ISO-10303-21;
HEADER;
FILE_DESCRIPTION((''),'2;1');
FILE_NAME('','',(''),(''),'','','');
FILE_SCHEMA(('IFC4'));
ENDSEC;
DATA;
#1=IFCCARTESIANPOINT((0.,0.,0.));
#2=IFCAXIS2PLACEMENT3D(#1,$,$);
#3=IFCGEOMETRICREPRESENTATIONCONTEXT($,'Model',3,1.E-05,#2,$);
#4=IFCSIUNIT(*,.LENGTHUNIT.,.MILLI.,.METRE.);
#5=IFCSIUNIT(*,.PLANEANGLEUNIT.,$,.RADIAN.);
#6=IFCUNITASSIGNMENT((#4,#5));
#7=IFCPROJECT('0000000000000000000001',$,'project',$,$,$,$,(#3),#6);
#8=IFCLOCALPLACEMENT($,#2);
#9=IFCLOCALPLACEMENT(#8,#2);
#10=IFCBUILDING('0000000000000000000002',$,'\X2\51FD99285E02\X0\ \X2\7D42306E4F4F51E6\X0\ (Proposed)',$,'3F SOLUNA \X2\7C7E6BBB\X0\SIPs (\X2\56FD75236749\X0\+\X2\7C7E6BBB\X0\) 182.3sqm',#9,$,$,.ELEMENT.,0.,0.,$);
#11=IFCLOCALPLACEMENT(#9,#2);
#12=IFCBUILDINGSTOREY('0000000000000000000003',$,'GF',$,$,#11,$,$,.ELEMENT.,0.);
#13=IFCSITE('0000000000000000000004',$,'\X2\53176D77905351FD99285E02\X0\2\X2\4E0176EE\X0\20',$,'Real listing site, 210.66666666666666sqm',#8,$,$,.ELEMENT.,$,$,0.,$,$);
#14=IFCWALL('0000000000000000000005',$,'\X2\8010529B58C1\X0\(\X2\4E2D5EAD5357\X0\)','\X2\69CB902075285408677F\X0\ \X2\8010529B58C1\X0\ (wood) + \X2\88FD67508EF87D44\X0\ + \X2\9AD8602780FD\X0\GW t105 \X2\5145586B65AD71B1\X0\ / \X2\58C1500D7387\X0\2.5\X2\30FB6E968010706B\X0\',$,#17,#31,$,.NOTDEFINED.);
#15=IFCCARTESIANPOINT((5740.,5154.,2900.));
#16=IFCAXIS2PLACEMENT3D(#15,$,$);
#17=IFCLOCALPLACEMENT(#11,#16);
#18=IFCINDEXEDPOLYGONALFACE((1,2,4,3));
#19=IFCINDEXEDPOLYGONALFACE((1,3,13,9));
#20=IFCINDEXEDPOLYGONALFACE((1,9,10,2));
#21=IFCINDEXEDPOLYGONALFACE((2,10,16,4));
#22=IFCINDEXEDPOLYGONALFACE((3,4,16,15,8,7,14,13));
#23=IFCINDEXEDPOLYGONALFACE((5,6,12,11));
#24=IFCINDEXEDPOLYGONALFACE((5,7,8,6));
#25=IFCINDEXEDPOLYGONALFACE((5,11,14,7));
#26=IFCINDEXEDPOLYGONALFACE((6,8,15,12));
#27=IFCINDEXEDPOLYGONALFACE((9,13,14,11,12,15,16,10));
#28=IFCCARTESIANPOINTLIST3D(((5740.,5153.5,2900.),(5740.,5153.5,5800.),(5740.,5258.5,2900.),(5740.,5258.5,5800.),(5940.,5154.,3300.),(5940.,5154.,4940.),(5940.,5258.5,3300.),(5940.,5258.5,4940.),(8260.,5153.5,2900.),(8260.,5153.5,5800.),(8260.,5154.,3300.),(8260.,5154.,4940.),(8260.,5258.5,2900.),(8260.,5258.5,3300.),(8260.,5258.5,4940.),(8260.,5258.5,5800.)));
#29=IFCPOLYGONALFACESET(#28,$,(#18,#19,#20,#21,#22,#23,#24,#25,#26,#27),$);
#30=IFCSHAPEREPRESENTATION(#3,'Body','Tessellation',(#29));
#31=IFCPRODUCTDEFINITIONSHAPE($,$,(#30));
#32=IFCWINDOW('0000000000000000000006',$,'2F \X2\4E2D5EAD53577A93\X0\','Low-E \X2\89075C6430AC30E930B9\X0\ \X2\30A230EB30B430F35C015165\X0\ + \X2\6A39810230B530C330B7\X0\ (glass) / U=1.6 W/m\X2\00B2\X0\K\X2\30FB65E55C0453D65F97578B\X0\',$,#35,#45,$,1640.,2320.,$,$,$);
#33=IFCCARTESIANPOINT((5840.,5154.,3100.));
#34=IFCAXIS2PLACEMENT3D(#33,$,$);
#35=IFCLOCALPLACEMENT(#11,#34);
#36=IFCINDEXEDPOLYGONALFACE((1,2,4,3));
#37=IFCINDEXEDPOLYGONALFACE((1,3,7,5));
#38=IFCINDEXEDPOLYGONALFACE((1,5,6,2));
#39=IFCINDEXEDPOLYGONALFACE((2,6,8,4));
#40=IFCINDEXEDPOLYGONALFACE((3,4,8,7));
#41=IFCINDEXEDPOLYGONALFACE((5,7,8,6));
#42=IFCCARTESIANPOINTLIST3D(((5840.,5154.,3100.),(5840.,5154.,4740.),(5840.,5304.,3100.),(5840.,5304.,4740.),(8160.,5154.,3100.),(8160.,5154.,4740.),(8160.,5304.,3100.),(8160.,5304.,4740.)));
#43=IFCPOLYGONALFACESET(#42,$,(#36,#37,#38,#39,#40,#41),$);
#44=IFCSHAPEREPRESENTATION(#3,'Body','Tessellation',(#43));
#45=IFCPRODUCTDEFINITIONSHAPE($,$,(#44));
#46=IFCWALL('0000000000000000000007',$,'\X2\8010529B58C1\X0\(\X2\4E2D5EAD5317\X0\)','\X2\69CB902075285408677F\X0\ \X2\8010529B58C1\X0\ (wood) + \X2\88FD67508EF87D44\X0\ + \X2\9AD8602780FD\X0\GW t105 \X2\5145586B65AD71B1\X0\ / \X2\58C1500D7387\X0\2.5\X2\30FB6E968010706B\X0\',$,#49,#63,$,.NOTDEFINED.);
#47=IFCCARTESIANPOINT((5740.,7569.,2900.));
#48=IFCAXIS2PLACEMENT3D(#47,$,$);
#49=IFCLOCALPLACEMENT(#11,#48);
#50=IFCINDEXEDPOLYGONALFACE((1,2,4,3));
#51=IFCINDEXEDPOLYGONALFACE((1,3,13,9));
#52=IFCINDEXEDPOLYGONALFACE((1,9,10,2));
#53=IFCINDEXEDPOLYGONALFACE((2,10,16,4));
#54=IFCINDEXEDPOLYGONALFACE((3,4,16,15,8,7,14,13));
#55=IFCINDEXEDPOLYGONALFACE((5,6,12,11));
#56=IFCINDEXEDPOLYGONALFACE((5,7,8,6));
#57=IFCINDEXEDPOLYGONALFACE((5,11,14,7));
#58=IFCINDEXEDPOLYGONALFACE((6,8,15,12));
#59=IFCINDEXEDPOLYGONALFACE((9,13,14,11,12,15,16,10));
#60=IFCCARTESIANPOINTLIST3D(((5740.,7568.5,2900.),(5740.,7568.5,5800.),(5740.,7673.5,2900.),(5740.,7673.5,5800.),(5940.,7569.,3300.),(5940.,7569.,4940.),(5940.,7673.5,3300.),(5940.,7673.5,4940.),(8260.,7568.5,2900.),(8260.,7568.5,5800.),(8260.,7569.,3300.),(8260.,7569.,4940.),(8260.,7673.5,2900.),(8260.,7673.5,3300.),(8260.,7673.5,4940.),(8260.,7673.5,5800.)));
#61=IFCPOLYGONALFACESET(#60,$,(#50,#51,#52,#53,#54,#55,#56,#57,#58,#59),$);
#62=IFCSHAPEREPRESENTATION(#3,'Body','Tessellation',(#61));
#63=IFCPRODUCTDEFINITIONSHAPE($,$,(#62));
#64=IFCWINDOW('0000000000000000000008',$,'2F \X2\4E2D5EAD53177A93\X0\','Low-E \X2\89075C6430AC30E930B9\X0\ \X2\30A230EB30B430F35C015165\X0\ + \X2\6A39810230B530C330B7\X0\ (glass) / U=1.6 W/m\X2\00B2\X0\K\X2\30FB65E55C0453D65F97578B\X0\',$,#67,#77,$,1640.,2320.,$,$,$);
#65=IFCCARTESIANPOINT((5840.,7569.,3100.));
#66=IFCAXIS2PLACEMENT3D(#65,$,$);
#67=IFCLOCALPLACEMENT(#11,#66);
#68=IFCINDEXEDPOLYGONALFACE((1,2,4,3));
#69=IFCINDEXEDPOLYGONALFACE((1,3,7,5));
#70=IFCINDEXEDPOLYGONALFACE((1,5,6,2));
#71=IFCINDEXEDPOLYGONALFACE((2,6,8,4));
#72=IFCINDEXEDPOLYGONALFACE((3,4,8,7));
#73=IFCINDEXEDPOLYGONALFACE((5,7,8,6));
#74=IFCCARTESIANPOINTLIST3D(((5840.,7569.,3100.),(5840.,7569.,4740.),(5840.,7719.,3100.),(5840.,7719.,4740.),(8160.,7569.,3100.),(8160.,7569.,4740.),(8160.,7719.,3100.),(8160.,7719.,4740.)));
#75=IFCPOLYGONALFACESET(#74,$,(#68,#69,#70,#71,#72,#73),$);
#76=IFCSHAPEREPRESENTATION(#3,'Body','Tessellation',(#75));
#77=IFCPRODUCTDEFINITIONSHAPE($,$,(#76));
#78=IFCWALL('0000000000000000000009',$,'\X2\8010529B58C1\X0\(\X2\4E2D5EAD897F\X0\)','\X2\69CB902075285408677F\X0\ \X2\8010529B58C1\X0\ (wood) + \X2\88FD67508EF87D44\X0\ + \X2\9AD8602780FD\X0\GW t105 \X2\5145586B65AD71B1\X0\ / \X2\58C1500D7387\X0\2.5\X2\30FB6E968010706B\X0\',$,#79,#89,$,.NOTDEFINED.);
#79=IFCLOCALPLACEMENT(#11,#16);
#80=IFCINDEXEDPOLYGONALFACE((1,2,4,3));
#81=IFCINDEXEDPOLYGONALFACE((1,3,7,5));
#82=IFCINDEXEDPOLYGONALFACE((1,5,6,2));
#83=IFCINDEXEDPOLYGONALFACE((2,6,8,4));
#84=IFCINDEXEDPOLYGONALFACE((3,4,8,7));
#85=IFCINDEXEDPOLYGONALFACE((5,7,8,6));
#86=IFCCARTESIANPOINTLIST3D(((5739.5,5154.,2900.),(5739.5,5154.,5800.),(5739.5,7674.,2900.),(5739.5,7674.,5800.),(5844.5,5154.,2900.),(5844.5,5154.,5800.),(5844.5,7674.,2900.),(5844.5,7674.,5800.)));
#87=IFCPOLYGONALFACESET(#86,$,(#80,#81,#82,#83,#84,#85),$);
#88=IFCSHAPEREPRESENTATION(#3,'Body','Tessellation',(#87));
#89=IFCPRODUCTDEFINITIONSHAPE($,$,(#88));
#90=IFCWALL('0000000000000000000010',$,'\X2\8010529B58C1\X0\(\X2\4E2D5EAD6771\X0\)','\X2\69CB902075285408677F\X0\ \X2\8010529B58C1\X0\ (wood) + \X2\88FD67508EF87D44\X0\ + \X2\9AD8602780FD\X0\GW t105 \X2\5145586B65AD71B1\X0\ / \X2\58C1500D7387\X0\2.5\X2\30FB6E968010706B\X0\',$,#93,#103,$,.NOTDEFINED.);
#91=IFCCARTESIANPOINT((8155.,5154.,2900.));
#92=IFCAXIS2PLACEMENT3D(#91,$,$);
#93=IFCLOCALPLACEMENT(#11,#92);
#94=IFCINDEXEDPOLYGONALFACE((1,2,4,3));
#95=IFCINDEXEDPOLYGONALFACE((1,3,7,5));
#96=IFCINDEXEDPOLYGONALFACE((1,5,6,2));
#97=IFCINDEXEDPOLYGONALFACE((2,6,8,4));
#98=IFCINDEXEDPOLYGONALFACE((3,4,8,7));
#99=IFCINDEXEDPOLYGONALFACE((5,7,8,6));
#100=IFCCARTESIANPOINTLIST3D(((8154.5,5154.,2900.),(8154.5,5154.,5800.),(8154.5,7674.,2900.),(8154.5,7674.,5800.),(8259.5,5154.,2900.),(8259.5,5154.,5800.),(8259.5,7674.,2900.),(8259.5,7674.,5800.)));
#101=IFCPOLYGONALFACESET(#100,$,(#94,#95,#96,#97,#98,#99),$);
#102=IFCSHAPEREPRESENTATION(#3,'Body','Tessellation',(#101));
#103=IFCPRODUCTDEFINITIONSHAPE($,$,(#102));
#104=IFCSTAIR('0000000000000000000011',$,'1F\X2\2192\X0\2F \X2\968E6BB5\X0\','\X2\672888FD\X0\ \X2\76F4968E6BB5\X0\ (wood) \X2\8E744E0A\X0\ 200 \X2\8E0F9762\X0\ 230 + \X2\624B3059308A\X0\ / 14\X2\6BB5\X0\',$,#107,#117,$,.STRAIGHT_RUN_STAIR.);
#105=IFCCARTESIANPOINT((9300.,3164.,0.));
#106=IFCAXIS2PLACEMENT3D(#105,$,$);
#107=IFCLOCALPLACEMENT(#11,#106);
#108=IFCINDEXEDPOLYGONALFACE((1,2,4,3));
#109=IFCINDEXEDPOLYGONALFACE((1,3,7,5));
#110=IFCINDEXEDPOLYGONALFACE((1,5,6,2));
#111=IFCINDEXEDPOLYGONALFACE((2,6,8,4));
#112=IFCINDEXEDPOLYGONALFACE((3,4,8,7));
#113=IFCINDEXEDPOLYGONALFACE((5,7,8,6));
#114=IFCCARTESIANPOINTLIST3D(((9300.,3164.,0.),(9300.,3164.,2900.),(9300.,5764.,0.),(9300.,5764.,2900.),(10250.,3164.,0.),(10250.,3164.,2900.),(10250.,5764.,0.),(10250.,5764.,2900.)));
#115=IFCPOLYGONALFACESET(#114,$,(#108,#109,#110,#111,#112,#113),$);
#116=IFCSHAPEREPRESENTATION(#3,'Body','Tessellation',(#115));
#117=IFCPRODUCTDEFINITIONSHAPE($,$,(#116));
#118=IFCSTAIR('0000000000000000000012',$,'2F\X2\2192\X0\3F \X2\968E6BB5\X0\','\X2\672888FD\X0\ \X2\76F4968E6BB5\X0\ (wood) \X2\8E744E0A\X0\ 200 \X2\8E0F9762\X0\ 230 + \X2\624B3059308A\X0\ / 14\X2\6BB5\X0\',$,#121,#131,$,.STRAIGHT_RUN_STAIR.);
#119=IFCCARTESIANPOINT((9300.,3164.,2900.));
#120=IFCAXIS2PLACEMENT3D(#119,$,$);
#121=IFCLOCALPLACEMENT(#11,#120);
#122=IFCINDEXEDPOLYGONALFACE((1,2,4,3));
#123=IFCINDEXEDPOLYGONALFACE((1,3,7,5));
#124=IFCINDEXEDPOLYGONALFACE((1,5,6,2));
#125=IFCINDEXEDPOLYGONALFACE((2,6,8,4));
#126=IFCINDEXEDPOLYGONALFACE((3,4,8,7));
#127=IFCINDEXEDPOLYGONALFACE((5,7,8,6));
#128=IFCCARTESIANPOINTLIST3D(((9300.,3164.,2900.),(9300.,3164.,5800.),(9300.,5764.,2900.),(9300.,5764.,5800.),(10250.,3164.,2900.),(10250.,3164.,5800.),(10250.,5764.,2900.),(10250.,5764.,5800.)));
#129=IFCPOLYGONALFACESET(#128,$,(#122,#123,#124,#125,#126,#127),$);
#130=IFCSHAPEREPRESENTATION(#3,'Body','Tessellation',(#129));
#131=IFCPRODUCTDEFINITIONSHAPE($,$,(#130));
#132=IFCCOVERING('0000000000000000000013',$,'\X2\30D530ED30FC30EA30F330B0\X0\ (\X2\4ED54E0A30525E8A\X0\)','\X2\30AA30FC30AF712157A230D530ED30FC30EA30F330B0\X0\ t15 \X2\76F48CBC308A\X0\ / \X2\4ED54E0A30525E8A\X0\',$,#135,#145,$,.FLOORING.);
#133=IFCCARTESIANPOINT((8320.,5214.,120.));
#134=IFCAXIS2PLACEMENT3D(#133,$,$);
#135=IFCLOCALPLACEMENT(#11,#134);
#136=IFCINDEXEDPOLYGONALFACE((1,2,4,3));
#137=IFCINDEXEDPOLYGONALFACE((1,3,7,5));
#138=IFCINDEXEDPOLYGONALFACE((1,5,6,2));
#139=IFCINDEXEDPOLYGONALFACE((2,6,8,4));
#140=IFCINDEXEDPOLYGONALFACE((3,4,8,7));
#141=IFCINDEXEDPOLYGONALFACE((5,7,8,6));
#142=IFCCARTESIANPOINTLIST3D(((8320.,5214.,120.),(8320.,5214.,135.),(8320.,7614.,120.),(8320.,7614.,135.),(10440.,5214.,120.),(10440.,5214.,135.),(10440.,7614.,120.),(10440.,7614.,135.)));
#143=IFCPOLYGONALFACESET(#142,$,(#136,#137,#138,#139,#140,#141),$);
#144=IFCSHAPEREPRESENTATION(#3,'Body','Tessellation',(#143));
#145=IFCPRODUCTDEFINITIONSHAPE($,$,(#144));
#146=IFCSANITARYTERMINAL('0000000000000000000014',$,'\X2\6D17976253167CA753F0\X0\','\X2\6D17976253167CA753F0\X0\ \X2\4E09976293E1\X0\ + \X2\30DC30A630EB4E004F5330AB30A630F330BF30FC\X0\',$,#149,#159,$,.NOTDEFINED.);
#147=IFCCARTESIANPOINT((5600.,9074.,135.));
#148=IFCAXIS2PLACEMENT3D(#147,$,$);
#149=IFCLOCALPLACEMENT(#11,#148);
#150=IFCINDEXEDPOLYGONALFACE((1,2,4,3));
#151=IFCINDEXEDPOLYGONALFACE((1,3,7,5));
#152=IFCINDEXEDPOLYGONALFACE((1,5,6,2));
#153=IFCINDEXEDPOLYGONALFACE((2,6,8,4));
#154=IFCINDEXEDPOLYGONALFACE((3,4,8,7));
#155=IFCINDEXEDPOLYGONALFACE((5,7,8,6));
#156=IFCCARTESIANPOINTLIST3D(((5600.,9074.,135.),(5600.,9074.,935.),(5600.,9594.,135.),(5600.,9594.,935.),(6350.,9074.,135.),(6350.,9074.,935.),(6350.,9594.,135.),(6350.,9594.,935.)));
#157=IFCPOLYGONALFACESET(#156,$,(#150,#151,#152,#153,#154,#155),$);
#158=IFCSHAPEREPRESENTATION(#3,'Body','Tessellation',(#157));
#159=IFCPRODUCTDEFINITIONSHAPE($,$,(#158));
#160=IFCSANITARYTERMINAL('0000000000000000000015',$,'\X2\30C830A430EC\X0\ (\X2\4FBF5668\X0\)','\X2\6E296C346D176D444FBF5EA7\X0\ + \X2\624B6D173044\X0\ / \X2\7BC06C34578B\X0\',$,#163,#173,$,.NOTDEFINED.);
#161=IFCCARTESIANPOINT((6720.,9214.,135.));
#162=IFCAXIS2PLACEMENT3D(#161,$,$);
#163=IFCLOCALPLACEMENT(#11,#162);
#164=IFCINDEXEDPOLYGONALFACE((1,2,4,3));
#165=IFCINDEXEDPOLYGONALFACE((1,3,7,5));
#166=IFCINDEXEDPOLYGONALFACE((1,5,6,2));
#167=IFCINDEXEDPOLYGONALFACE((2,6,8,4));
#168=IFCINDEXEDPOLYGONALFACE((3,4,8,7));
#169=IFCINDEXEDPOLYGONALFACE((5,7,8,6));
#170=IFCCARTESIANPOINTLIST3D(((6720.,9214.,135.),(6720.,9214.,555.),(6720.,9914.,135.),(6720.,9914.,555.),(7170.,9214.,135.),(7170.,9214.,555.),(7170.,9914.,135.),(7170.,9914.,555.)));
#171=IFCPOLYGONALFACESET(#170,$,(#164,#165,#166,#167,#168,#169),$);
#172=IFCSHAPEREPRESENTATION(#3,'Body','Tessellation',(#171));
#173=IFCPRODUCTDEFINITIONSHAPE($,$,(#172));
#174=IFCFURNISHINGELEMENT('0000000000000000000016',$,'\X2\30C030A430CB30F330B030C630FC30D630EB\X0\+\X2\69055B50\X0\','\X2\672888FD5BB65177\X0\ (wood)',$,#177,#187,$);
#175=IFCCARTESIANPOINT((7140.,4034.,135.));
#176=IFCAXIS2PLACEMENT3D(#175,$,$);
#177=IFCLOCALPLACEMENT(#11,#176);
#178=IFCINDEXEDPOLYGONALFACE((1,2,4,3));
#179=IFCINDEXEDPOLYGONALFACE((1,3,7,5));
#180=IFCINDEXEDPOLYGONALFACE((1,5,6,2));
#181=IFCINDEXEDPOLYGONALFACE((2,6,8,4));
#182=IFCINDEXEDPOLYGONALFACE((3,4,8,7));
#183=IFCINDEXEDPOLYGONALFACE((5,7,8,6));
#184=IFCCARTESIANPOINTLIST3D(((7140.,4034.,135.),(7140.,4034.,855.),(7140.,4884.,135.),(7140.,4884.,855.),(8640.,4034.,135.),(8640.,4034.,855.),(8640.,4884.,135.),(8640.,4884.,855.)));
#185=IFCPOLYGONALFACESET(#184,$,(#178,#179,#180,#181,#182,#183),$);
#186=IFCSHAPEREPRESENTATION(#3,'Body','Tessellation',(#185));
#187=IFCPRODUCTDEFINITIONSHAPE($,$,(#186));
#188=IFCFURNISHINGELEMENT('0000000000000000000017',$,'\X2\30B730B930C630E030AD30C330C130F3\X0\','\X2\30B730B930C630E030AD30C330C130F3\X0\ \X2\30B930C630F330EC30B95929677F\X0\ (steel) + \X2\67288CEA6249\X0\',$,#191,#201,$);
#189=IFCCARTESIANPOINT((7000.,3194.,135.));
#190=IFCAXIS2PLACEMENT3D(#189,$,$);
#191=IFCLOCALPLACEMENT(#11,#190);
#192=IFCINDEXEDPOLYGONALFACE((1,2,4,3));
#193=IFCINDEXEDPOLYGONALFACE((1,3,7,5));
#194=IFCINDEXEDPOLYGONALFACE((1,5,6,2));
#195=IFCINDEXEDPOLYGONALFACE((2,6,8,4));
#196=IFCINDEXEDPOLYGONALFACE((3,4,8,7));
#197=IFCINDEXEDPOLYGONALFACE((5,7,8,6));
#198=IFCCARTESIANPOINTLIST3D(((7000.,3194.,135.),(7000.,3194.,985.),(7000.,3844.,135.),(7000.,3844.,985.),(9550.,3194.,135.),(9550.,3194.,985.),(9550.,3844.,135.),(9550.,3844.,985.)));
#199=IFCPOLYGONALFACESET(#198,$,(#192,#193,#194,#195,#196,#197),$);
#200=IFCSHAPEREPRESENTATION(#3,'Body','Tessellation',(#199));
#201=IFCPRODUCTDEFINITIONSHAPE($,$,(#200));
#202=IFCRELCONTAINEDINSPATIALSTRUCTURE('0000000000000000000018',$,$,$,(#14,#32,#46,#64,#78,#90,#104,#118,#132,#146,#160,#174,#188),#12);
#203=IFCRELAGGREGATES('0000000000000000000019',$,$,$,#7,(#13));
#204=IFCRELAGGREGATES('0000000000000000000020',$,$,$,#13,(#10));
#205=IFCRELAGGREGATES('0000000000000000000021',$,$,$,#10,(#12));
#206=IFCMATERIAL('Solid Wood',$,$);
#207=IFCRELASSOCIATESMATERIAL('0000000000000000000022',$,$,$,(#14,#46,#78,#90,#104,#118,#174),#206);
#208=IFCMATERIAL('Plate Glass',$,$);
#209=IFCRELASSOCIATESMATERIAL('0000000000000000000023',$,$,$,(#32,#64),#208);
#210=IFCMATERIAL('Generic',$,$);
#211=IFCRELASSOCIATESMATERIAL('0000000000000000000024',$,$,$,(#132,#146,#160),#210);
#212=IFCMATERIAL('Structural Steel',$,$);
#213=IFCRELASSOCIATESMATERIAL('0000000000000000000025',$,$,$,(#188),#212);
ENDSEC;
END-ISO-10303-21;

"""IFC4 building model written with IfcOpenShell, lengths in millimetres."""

from ifc_helpers import new_model, si_unit, frame, frame_2d, origin, place, context, project, spatial, rectangle, extrude, material, element, fill, save


model = new_model("IFC4")

# Units and contexts
model_context = context("Model", 3, precision=1e-05, world=origin())
ifc_project = project(units=[si_unit("LENGTHUNIT", "METRE", prefix="MILLI"), si_unit("PLANEANGLEUNIT", "RADIAN")], contexts=[model_context])

# Site, building, storey
site_placement = place(None, origin())
site = spatial("IfcSite", under=ifc_project, at=site_placement, Name="北海道函館市2丁目20", ObjectType="Real listing site, 210.66666666666666sqm", CompositionType="ELEMENT", RefElevation=0.0)
building_placement = place(site_placement, origin())
building = spatial("IfcBuilding", under=site, at=building_placement, Name="函館市 終の住処 (Proposed)", ObjectType="3F SOLUNA 籾殻SIPs (国産杉+籾殻) 182.3sqm", CompositionType="ELEMENT", ElevationOfRefHeight=0.0, ElevationOfTerrain=0.0)
storey_placement = place(building_placement, origin())
storey = spatial("IfcBuildingStorey", under=building, at=storey_placement, Name="GF", CompositionType="ELEMENT", Elevation=0.0)

# Shared definitions
ifc_material_1 = material(Name="Solid Wood")

# Shared definitions
ifc_material_2 = material(Name="Plate Glass")

# Walls, openings, windows
wall_1_placement = place(storey_placement, frame((5740.0, 5154.0, 2900.0)))
wall_1 = element("IfcWall", 1, at=wall_1_placement, inside=storey, material=ifc_material_1, Name="耐力壁(中庭南)", Description="構造用合板 耐力壁 (wood) + 製材軸組 + 高性能GW t105 充填断熱 / 壁倍率2.5・準耐火", PredefinedType="NOTDEFINED", context=model_context, shape_type="SweptSolid", body=[
    extrude(rectangle(XDim=2520.0, YDim=105.0, at=frame_2d((1260.0, 52.0))), frame((5740.0, 5154.0, 2900.0)), (0.0, 0.0, 1.0), 2900.0),
])
opening_1_placement = place(storey_placement, frame((5840.0, 5154.0, 3100.0)))
opening_1 = element("IfcOpeningElement", 2, at=opening_1_placement, cuts=wall_1, PredefinedType="NOTDEFINED", context=model_context, shape_type="SweptSolid", body=[
    extrude(rectangle(XDim=2320.0, YDim=150.0, at=frame_2d((1160.0, 75.0))), frame((5840.0, 5154.0, 3100.0)), (0.0, 0.0, 1.0), 1640.0),
])
window_1_placement = place(storey_placement, frame((5840.0, 5154.0, 3100.0)))
window_1 = element("IfcWindow", 3, at=window_1_placement, inside=storey, material=ifc_material_2, Name="2F 中庭南窓", Description="Low-E 複層ガラス アルゴン封入 + 樹脂サッシ (glass) / U=1.6 W/m²K・日射取得型", OverallHeight=1640.0, OverallWidth=2320.0, context=model_context, shape_type="SweptSolid", body=[
    extrude(rectangle(XDim=2320.0, YDim=150.0, at=frame_2d((1160.0, 75.0))), frame((5840.0, 5154.0, 3100.0)), (0.0, 0.0, 1.0), 1640.0),
])
fill(opening_1, window_1)
wall_2_placement = place(storey_placement, frame((5740.0, 7569.0, 2900.0)))
wall_2 = element("IfcWall", 4, at=wall_2_placement, inside=storey, material=ifc_material_1, Name="耐力壁(中庭北)", Description="構造用合板 耐力壁 (wood) + 製材軸組 + 高性能GW t105 充填断熱 / 壁倍率2.5・準耐火", PredefinedType="NOTDEFINED", context=model_context, shape_type="SweptSolid", body=[
    extrude(rectangle(XDim=2520.0, YDim=105.0, at=frame_2d((1260.0, 52.0))), frame((5740.0, 7569.0, 2900.0)), (0.0, 0.0, 1.0), 2900.0),
])
opening_2_placement = place(storey_placement, frame((5840.0, 7569.0, 3100.0)))
opening_2 = element("IfcOpeningElement", 5, at=opening_2_placement, cuts=wall_2, PredefinedType="NOTDEFINED", context=model_context, shape_type="SweptSolid", body=[
    extrude(rectangle(XDim=2320.0, YDim=150.0, at=frame_2d((1160.0, 75.0))), frame((5840.0, 7569.0, 3100.0)), (0.0, 0.0, 1.0), 1640.0),
])
window_2_placement = place(storey_placement, frame((5840.0, 7569.0, 3100.0)))
window_2 = element("IfcWindow", 6, at=window_2_placement, inside=storey, material=ifc_material_2, Name="2F 中庭北窓", Description="Low-E 複層ガラス アルゴン封入 + 樹脂サッシ (glass) / U=1.6 W/m²K・日射取得型", OverallHeight=1640.0, OverallWidth=2320.0, context=model_context, shape_type="SweptSolid", body=[
    extrude(rectangle(XDim=2320.0, YDim=150.0, at=frame_2d((1160.0, 75.0))), frame((5840.0, 7569.0, 3100.0)), (0.0, 0.0, 1.0), 1640.0),
])
fill(opening_2, window_2)

# Walls
wall_3_placement = place(storey_placement, frame((5740.0, 5154.0, 2900.0)))
element("IfcWall", 7, at=wall_3_placement, inside=storey, material=ifc_material_1, Name="耐力壁(中庭西)", Description="構造用合板 耐力壁 (wood) + 製材軸組 + 高性能GW t105 充填断熱 / 壁倍率2.5・準耐火", PredefinedType="NOTDEFINED", context=model_context, shape_type="SweptSolid", body=[
    extrude(rectangle(XDim=105.0, YDim=2520.0, at=frame_2d((52.0, 1260.0))), frame((5740.0, 5154.0, 2900.0)), (0.0, 0.0, 1.0), 2900.0),
])
wall_4_placement = place(storey_placement, frame((8155.0, 5154.0, 2900.0)))
element("IfcWall", 8, at=wall_4_placement, inside=storey, material=ifc_material_1, Name="耐力壁(中庭東)", Description="構造用合板 耐力壁 (wood) + 製材軸組 + 高性能GW t105 充填断熱 / 壁倍率2.5・準耐火", PredefinedType="NOTDEFINED", context=model_context, shape_type="SweptSolid", body=[
    extrude(rectangle(XDim=105.0, YDim=2520.0, at=frame_2d((52.0, 1260.0))), frame((8155.0, 5154.0, 2900.0)), (0.0, 0.0, 1.0), 2900.0),
])

# Stairs
stair_1_placement = place(storey_placement, frame((9300.0, 3164.0, 0.0)))
element("IfcStair", 9, at=stair_1_placement, inside=storey, material=ifc_material_1, Name="1F→2F 階段", Description="木製 直階段 (wood) 蹴上 200 踏面 230 + 手すり / 14段", PredefinedType="STRAIGHT_RUN_STAIR", context=model_context, shape_type="SweptSolid", body=[
    extrude(rectangle(XDim=950.0, YDim=2600.0, at=frame_2d((475.0, 1300.0))), frame((9300.0, 3164.0, 0.0)), (0.0, 0.0, 1.0), 2900.0),
])
stair_2_placement = place(storey_placement, frame((9300.0, 3164.0, 2900.0)))
element("IfcStair", 10, at=stair_2_placement, inside=storey, material=ifc_material_1, Name="2F→3F 階段", Description="木製 直階段 (wood) 蹴上 200 踏面 230 + 手すり / 14段", PredefinedType="STRAIGHT_RUN_STAIR", context=model_context, shape_type="SweptSolid", body=[
    extrude(rectangle(XDim=950.0, YDim=2600.0, at=frame_2d((475.0, 1300.0))), frame((9300.0, 3164.0, 2900.0)), (0.0, 0.0, 1.0), 2900.0),
])

# Covering
ifc_material_3 = material(Name="Generic")
covering_placement = place(storey_placement, frame((8320.0, 5214.0, 120.0)))
element("IfcCovering", 11, at=covering_placement, inside=storey, material=ifc_material_3, Name="フローリング (仕上げ床)", Description="オーク無垢フローリング t15 直貼り / 仕上げ床", PredefinedType="FLOORING", context=model_context, shape_type="SweptSolid", body=[
    extrude(rectangle(XDim=2120.0, YDim=2400.0, at=frame_2d((1060.0, 1200.0))), frame((8320.0, 5214.0, 120.0)), (0.0, 0.0, 1.0), 15.0),
])

# Sanitary terminals
sanitary_terminal_1_placement = place(storey_placement, frame((5600.0, 9074.0, 135.0)))
element("IfcSanitaryTerminal", 12, at=sanitary_terminal_1_placement, inside=storey, material=ifc_material_3, Name="洗面化粧台", Description="洗面化粧台 三面鏡 + ボウル一体カウンター", PredefinedType="NOTDEFINED", context=model_context, shape_type="SweptSolid", body=[
    extrude(rectangle(XDim=750.0, YDim=520.0, at=frame_2d((375.0, 260.0))), frame((5600.0, 9074.0, 135.0)), (0.0, 0.0, 1.0), 800.0),
])
sanitary_terminal_2_placement = place(storey_placement, frame((6720.0, 9214.0, 135.0)))
element("IfcSanitaryTerminal", 13, at=sanitary_terminal_2_placement, inside=storey, material=ifc_material_3, Name="トイレ (便器)", Description="温水洗浄便座 + 手洗い / 節水型", PredefinedType="NOTDEFINED", context=model_context, shape_type="SweptSolid", body=[
    extrude(rectangle(XDim=450.0, YDim=700.0, at=frame_2d((225.0, 350.0))), frame((6720.0, 9214.0, 135.0)), (0.0, 0.0, 1.0), 420.0),
])

# Furnishing elements
furnishing_1_placement = place(storey_placement, frame((7140.0, 4034.0, 135.0)))
element("IfcFurnishingElement", 14, at=furnishing_1_placement, inside=storey, material=ifc_material_1, Name="ダイニングテーブル+椅子", Description="木製家具 (wood)", context=model_context, shape_type="SweptSolid", body=[
    extrude(rectangle(XDim=1500.0, YDim=850.0, at=frame_2d((750.0, 425.0))), frame((7140.0, 4034.0, 135.0)), (0.0, 0.0, 1.0), 720.0),
])
ifc_material_4 = material(Name="Structural Steel")
furnishing_2_placement = place(storey_placement, frame((7000.0, 3194.0, 135.0)))
element("IfcFurnishingElement", 15, at=furnishing_2_placement, inside=storey, material=ifc_material_4, Name="システムキッチン", Description="システムキッチン ステンレス天板 (steel) + 木質扉", context=model_context, shape_type="SweptSolid", body=[
    extrude(rectangle(XDim=2550.0, YDim=650.0, at=frame_2d((1275.0, 325.0))), frame((7000.0, 3194.0, 135.0)), (0.0, 0.0, 1.0), 850.0),
])

save(model, "model.ifc")
